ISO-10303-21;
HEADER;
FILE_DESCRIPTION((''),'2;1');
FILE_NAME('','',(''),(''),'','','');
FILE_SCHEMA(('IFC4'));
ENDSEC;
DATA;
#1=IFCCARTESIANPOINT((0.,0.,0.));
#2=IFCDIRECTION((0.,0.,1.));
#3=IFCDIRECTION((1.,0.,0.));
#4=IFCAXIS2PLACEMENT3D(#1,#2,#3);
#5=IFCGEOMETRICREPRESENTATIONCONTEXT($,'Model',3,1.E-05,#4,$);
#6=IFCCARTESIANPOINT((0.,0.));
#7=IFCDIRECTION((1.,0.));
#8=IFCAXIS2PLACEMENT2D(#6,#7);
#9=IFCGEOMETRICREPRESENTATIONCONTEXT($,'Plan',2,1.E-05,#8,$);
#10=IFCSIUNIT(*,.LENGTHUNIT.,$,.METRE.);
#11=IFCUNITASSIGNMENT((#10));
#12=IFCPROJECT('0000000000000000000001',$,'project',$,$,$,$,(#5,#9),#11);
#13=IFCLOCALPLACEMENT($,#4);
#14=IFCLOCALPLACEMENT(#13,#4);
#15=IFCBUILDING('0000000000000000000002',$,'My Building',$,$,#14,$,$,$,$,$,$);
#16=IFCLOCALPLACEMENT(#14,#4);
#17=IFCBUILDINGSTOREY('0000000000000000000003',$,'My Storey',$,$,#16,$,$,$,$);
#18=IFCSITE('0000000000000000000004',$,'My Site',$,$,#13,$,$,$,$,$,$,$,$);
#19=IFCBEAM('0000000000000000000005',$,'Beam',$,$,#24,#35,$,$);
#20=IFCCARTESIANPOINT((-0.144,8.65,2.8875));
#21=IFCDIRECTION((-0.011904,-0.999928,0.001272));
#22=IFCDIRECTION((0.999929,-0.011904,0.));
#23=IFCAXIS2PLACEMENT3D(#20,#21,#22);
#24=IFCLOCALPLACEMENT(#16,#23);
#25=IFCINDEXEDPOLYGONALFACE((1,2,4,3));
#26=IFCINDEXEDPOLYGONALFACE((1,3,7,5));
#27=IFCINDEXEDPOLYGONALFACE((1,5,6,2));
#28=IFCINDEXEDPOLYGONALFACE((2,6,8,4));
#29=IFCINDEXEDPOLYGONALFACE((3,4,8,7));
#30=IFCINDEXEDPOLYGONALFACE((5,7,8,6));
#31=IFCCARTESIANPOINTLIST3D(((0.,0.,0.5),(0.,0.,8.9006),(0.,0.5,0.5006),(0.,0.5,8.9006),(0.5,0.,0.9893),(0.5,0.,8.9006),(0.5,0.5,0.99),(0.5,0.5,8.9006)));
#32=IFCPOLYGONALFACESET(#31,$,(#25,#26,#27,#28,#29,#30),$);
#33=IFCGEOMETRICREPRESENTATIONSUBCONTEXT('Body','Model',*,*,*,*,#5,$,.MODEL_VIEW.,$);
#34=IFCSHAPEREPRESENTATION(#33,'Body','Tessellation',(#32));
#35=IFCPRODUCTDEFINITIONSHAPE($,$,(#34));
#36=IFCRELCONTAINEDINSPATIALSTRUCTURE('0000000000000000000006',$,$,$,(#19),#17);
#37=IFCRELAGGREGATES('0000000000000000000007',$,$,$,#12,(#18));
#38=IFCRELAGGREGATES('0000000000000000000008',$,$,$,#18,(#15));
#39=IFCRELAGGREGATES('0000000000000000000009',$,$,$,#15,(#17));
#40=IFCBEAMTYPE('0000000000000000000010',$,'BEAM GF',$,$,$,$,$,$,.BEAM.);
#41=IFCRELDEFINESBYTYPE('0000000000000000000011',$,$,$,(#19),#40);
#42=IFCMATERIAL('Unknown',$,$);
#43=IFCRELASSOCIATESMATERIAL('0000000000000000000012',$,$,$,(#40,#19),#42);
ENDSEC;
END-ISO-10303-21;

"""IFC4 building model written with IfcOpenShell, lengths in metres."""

from ifc_helpers import new_model, si_unit, frame, origin_with_axes, origin_2d_with_axis, place, context, subcontext, project, spatial, rectangle, extrude, clip, halfspace, material, material_profile, profile_set, profile_usage, type_object, element, save


model = new_model("IFC4")

# Units and contexts
model_context = context("Model", 3, precision=1e-05, world=origin_with_axes())
plan_context = context("Plan", 2, precision=1e-05, world=origin_2d_with_axis())
body_context_1 = subcontext(model_context, "Body", "Model", "MODEL_VIEW")
ifc_project = project(units=[si_unit("LENGTHUNIT", "METRE")], contexts=[model_context, plan_context])

# Site, building, storey
site_placement = place(None, origin_with_axes())
site = spatial("IfcSite", under=ifc_project, at=site_placement, Name="My Site")
building_placement = place(site_placement, origin_with_axes())
building = spatial("IfcBuilding", under=site, at=building_placement, Name="My Building")
storey_placement = place(building_placement, origin_with_axes())
storey = spatial("IfcBuildingStorey", under=building, at=storey_placement, Name="My Storey")

# Shared definitions
ifc_material = material(Name="Unknown")

# Beam
ifc_material_profile_1 = material_profile(ifc_material, rectangle(XDim=0.5, YDim=0.5))
ifc_profile_set_1 = profile_set([ifc_material_profile_1])
beam_type = type_object("IfcBeamType", Name="BEAM GF", PredefinedType="BEAM", material=ifc_profile_set_1)
ifc_profile_usage_1 = profile_usage(ifc_profile_set_1, cardinal=3)
beam_1_placement = place(storey_placement, frame((-0.144, 8.65, 2.8875), z_axis=(-0.011904, -0.999928, 0.001272), x_axis=(0.999929, -0.011904, 0.0)))
element("IfcBeam", 1, at=beam_1_placement, inside=storey, type_object=beam_type, material=ifc_profile_usage_1, Name="Beam", context=body_context_1, shape_type="Clipping", body=[
    clip(extrude(rectangle(XDim=0.5, YDim=0.5), frame((0.25, 0.25, 0.0), z_axis=(0.0, 0.0, 1.0), x_axis=(1.0, 0.0, 0.0)), (0.0, 0.0, 1.0), 8.9006), halfspace(frame((0.0, -2.9846, 0.4962), z_axis=(0.699451, 0.000909, -0.71468), x_axis=(0.001299, -0.999999, 0.0)), False)),
])

save(model, "model.ifc")
